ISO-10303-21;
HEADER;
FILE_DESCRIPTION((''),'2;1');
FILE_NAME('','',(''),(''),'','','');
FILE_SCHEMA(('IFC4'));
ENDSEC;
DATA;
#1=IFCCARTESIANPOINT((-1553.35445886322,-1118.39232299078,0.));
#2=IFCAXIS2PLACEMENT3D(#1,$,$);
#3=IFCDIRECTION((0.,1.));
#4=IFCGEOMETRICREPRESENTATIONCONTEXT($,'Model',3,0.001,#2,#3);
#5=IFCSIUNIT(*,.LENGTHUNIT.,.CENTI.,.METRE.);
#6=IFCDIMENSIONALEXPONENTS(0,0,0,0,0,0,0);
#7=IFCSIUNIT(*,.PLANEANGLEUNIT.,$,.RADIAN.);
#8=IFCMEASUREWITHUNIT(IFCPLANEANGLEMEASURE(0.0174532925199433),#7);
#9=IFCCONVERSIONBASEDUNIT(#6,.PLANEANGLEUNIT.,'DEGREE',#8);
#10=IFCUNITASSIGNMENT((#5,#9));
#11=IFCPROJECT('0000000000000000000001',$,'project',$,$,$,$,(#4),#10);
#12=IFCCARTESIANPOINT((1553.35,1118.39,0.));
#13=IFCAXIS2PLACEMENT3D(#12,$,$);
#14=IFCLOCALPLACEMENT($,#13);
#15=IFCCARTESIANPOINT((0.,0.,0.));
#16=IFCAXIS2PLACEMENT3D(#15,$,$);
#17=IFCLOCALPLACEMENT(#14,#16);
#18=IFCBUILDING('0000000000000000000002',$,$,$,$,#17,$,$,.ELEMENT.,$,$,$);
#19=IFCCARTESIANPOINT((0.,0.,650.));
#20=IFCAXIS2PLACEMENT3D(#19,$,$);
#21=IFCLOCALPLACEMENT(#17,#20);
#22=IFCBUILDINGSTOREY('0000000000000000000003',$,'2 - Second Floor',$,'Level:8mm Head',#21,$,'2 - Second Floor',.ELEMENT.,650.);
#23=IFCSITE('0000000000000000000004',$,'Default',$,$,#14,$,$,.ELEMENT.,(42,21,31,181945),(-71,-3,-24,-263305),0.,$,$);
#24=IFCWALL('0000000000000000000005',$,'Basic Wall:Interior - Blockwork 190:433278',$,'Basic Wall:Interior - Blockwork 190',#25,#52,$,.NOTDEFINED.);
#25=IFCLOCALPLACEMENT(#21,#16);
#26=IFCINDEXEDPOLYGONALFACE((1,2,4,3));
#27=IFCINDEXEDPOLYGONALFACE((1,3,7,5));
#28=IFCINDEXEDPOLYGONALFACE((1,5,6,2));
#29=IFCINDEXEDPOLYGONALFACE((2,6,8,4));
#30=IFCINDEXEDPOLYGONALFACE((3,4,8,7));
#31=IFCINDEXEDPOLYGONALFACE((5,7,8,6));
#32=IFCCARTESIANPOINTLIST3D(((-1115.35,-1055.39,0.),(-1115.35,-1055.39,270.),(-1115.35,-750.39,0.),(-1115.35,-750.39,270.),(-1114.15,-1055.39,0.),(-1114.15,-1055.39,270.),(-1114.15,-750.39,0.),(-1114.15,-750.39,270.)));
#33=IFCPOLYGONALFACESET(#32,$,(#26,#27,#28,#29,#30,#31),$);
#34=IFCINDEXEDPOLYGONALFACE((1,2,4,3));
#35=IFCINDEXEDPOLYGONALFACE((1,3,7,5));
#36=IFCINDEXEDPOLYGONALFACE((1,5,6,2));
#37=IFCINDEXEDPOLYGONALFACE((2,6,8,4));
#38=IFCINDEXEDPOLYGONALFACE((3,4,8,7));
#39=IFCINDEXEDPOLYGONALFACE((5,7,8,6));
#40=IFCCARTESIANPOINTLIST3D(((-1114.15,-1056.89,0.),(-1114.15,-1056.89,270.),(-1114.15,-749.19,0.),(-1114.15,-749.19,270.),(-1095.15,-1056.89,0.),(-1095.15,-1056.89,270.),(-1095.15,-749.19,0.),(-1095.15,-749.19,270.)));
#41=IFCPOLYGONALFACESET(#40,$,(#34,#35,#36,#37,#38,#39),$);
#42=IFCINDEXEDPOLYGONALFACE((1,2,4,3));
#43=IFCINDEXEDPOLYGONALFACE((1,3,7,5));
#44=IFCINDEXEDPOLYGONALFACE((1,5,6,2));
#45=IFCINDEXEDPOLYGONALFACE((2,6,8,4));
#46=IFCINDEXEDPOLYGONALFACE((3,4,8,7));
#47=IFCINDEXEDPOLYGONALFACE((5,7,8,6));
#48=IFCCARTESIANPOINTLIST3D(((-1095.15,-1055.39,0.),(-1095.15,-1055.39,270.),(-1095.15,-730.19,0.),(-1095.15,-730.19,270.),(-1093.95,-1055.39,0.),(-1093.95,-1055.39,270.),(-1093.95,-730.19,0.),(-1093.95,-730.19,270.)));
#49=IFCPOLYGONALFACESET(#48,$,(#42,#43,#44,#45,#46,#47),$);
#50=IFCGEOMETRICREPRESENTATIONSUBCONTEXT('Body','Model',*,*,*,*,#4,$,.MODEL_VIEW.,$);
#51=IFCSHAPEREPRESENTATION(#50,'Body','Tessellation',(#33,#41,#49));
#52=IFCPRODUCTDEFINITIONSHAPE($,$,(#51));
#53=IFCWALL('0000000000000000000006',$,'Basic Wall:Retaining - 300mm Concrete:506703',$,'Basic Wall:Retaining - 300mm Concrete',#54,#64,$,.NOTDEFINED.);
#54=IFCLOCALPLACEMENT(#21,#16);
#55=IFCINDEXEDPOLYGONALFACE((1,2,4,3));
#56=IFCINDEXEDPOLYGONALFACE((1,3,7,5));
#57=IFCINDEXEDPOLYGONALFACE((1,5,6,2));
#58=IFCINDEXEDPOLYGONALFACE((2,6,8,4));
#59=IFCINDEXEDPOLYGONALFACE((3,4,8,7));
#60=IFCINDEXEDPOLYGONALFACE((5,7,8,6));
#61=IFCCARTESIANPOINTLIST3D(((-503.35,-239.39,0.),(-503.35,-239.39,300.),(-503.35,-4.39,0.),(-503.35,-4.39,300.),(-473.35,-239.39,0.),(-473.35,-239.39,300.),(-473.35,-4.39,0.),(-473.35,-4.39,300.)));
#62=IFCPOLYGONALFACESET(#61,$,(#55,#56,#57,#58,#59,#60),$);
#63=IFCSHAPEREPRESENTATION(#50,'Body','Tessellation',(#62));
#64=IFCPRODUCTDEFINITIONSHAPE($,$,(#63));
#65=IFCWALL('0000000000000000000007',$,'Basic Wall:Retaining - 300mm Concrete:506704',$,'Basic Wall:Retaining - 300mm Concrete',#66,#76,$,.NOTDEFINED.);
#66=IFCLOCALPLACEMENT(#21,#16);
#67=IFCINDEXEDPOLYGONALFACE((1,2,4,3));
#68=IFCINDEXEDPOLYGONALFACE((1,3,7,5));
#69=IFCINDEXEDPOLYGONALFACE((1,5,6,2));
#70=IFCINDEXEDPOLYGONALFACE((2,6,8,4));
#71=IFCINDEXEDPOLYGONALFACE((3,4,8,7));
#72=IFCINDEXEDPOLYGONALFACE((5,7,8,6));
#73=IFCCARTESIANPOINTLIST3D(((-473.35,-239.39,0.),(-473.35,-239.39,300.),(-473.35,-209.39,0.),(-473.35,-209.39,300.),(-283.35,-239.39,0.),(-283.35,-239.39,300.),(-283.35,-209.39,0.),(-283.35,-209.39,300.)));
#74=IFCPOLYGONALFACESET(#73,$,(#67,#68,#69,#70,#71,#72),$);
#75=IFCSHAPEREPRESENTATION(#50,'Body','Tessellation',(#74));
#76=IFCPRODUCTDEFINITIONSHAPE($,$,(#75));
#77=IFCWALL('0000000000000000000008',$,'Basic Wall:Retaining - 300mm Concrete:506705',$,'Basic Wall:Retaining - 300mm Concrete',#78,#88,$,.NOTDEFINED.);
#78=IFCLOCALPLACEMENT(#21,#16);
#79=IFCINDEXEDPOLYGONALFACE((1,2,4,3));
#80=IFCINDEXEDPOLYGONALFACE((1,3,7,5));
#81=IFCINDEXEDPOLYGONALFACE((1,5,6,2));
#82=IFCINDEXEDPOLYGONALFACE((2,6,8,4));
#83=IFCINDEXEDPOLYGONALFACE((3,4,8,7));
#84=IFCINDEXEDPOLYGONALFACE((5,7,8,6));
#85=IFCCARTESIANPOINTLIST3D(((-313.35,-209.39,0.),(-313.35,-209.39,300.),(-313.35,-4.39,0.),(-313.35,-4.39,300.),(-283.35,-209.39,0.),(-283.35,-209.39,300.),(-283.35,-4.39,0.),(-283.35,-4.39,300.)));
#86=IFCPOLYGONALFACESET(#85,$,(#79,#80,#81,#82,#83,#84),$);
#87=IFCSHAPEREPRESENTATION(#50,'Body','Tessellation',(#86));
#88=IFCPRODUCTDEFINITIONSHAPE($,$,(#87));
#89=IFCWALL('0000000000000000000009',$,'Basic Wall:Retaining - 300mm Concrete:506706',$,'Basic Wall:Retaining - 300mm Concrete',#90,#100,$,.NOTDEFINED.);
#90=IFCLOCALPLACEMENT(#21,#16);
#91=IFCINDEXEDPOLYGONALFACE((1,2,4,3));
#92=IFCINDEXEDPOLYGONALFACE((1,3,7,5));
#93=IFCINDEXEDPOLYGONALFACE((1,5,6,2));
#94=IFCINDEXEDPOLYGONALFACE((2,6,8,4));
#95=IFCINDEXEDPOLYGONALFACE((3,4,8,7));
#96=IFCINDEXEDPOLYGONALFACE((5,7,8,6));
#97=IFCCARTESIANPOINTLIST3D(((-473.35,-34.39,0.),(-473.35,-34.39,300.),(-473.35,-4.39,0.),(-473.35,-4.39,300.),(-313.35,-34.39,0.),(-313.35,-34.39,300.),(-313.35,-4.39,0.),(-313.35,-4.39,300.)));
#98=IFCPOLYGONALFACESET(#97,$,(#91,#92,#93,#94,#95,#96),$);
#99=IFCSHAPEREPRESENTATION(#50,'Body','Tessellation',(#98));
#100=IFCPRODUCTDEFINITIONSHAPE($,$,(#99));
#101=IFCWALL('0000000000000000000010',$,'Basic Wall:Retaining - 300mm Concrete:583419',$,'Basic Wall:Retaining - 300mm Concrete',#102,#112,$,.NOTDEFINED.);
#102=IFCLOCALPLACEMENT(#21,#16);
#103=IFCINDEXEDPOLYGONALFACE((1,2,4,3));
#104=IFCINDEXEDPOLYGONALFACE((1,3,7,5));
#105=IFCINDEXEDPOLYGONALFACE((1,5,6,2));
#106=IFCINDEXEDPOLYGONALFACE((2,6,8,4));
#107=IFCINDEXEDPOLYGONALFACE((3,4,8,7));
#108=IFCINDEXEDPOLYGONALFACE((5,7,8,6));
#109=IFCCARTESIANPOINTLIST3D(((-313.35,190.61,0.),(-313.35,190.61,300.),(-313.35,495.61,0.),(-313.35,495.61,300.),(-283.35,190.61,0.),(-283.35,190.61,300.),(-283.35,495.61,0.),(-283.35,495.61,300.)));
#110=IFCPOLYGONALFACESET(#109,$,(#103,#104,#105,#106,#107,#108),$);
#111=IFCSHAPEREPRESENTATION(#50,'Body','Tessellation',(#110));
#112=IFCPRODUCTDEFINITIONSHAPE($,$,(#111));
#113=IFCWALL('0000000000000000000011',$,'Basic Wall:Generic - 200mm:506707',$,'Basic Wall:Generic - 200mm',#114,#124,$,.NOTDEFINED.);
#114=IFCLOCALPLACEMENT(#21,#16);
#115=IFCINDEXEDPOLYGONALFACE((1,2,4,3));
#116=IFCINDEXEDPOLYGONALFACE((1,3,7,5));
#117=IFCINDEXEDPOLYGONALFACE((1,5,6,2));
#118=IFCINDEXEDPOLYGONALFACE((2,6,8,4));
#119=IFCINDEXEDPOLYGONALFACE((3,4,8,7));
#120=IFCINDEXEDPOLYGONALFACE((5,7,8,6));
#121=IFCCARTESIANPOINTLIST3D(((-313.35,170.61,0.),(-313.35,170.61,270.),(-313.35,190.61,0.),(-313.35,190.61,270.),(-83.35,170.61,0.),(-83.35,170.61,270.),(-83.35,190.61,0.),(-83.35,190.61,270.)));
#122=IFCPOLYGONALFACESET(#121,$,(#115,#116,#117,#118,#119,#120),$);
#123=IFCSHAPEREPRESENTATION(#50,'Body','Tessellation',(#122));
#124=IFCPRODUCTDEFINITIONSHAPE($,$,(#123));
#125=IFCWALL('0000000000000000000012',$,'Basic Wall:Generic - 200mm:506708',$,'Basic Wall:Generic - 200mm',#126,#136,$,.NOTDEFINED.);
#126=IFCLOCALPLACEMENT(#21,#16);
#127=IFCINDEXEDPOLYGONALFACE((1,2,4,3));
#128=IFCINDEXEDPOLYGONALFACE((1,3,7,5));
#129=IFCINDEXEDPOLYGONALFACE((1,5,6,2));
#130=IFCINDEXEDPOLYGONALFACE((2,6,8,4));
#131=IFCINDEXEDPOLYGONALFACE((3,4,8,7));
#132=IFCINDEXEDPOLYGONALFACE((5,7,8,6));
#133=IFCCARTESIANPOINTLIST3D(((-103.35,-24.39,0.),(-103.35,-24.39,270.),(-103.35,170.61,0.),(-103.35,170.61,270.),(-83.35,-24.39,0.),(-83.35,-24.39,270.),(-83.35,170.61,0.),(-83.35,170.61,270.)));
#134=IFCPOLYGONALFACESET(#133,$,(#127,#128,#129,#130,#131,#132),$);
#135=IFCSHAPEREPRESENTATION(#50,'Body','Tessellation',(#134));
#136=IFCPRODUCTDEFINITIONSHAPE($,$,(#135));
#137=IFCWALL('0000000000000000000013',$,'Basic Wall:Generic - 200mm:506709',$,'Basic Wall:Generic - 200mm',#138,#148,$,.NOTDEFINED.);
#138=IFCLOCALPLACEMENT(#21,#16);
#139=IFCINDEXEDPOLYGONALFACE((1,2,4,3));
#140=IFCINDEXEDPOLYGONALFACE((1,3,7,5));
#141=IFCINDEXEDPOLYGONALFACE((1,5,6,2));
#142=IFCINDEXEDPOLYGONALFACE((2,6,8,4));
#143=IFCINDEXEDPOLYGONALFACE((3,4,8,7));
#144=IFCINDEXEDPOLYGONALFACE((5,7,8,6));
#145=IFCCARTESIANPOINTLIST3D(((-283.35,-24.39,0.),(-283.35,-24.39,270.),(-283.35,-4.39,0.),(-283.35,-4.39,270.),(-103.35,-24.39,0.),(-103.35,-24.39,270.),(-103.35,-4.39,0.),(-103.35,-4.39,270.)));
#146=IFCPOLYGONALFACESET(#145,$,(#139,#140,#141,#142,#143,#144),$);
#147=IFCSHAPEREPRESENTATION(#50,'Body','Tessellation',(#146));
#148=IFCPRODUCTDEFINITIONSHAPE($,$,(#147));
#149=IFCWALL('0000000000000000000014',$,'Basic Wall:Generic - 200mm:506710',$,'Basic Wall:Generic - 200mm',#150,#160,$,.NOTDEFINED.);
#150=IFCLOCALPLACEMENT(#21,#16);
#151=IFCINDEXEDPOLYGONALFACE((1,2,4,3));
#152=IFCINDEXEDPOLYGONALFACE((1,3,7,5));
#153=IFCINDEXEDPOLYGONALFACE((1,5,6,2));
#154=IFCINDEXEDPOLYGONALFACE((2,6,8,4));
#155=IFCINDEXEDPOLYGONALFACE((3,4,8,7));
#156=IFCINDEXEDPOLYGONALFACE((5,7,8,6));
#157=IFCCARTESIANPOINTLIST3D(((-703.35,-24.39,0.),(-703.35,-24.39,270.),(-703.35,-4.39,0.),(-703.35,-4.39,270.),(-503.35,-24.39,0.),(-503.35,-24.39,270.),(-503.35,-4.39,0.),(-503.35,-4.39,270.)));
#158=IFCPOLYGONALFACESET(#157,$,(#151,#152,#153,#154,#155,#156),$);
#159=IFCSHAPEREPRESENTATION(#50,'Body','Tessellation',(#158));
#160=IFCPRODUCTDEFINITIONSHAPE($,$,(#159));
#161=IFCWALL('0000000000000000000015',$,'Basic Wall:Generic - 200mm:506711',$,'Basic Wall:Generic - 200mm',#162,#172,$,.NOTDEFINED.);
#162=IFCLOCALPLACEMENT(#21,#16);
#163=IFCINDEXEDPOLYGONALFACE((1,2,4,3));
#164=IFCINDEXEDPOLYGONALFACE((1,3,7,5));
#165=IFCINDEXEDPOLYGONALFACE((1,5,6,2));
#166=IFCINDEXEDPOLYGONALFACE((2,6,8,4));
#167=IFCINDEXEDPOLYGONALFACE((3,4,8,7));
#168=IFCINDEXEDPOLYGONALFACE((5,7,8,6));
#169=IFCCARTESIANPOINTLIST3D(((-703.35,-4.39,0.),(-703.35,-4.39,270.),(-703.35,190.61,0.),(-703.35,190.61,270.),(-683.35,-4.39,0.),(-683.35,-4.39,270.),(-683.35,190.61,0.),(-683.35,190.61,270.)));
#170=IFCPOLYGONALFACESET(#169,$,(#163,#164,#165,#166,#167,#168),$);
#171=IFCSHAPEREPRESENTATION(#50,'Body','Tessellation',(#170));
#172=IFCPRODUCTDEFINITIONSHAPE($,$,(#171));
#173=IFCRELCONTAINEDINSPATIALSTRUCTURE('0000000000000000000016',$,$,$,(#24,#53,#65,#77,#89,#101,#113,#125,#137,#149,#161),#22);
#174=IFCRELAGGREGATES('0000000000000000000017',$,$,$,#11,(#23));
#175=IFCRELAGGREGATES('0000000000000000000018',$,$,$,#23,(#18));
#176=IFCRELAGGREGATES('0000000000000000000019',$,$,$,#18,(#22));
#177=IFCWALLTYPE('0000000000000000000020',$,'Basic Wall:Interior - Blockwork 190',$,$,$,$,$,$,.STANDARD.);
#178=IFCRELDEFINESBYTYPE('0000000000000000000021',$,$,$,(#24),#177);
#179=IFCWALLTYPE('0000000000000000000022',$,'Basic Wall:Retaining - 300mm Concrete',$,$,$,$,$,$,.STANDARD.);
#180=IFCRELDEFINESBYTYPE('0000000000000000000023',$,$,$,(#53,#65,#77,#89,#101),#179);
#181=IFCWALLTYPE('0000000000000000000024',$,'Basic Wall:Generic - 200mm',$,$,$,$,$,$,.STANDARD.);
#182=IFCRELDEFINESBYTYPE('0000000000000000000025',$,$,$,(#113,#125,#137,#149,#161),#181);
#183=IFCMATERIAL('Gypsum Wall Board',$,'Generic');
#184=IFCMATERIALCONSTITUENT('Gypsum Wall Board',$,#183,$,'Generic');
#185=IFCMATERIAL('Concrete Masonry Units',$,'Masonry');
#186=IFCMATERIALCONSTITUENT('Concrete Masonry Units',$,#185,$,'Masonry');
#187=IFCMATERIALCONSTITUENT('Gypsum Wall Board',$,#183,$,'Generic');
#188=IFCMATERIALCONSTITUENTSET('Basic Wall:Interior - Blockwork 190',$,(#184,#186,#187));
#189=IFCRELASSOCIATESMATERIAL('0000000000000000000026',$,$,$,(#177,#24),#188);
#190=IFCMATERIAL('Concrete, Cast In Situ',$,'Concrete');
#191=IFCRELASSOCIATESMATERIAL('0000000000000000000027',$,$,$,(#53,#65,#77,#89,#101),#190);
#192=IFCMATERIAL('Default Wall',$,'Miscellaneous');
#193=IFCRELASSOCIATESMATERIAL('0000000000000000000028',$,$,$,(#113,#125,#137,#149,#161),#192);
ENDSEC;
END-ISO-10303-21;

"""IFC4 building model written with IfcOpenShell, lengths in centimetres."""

from ifc_helpers import new_model, entity, si_unit, converted_unit, direction, frame, origin, place, context, subcontext, project, spatial, indexed_curve, outline, extrude, material, constituent, constituent_set, type_object, element, save


model = new_model("IFC4")

# Units and contexts
model_context = context("Model", 3, precision=0.001, world=frame((-1553.35445886322, -1118.39232299078, 0.0)), true_north=direction((0.0, 1.0)))
body_context = subcontext(model_context, "Body", "Model", "MODEL_VIEW")
ifc_project = project(units=[si_unit("LENGTHUNIT", "METRE", prefix="CENTI"), converted_unit("PLANEANGLEUNIT", "DEGREE", entity("IfcPlaneAngleMeasure", 0.0174532925199433), si_unit("PLANEANGLEUNIT", "RADIAN"), dimensions=[0, 0, 0, 0, 0, 0, 0])], contexts=[model_context])

# Site, building, storey
site_placement = place(None, frame((1553.35, 1118.39, 0.0)))
site = spatial("IfcSite", under=ifc_project, at=site_placement, Name="Default", CompositionType="ELEMENT", RefLatitude=(42, 21, 31, 181945), RefLongitude=(-71, -3, -24, -263305), RefElevation=0.0)
building_placement = place(site_placement, origin())
building = spatial("IfcBuilding", under=site, at=building_placement, CompositionType="ELEMENT")
storey_placement = place(building_placement, frame((0.0, 0.0, 650.0)))
storey = spatial("IfcBuildingStorey", under=building, at=storey_placement, Name="2 - Second Floor", ObjectType="Level:8mm Head", LongName="2 - Second Floor", CompositionType="ELEMENT", Elevation=650.0)

# Shared definitions
ifc_material_1 = material(Name="Concrete Masonry Units", Category="Masonry")

# Shared definitions
ifc_material_2 = material(Name="Gypsum Wall Board", Category="Generic")
ifc_constituent_1 = constituent(ifc_material_2, Name="Gypsum Wall Board", Category="Generic")
ifc_constituent_2 = constituent(ifc_material_1, Name="Concrete Masonry Units", Category="Masonry")
ifc_constituent_3 = constituent(ifc_material_2, Name="Gypsum Wall Board", Category="Generic")
ifc_constituent_set_1 = constituent_set(constituents=[ifc_constituent_1, ifc_constituent_2, ifc_constituent_3], Name="Basic Wall:Interior - Blockwork 190")
wall_type_1 = type_object("IfcWallType", Name="Basic Wall:Interior - Blockwork 190", PredefinedType="STANDARD", material=ifc_constituent_set_1)

# Walls
wall_1_placement = place(storey_placement, frame((-1104.65, -750.39, 0.0), z_axis=(0.0, 0.0, 1.0), x_axis=(0.0, -1.0, 0.0)))
element("IfcWall", 1, at=wall_1_placement, inside=storey, type_object=wall_type_1, material=ifc_constituent_set_1, Name="Basic Wall:Interior - Blockwork 190:433278", ObjectType="Basic Wall:Interior - Blockwork 190", PredefinedType="NOTDEFINED", context=body_context, shape_type="SweptSolid", body=[
    extrude(outline(indexed_curve([(-0.6, -152.5), (0.6, -152.5), (0.6, 152.5), (-0.6, 152.5), (-0.6, -152.5)], self_intersect=False)), frame((152.5, -10.1, 0.0), z_axis=(0.0, 0.0, 1.0), x_axis=(0.0, 1.0, 0.0)), (0.0, 0.0, 1.0), 270.0),
    extrude(outline(indexed_curve([(-153.85, -9.5), (153.85, -9.5), (153.85, 9.5), (-153.85, 9.5), (-153.85, -9.5)], self_intersect=False)), frame((152.65, 0.0, 0.0)), (0.0, 0.0, 1.0), 270.0),
    extrude(outline(indexed_curve([(-0.6, -162.6), (0.6, -162.6), (0.6, 162.6), (-0.6, 162.6), (-0.6, -162.6)], self_intersect=False)), frame((142.4, 10.1, 0.0), z_axis=(0.0, 0.0, 1.0), x_axis=(0.0, -1.0, 0.0)), (0.0, 0.0, 1.0), 270.0),
])
ifc_material_3 = material(Name="Concrete, Cast In Situ", Category="Concrete")
wall_type_2 = type_object("IfcWallType", Name="Basic Wall:Retaining - 300mm Concrete", PredefinedType="STANDARD")
wall_2_placement = place(storey_placement, frame((-488.35, -4.39, 0.0), z_axis=(0.0, 0.0, 1.0), x_axis=(0.0, -1.0, 0.0)))
element("IfcWall", 2, at=wall_2_placement, inside=storey, type_object=wall_type_2, material=ifc_material_3, Name="Basic Wall:Retaining - 300mm Concrete:506703", ObjectType="Basic Wall:Retaining - 300mm Concrete", PredefinedType="NOTDEFINED", context=body_context, shape_type="SweptSolid", body=[
    extrude(outline(indexed_curve([(235.0, 15.0), (0.0, 15.0), (0.0, -15.0), (235.0, -15.0), (235.0, 15.0)], self_intersect=False)), origin(), (0.0, 0.0, 1.0), 300.0),
])
wall_3_placement = place(storey_placement, frame((-473.35, -224.39, 0.0)))
element("IfcWall", 3, at=wall_3_placement, inside=storey, type_object=wall_type_2, material=ifc_material_3, Name="Basic Wall:Retaining - 300mm Concrete:506704", ObjectType="Basic Wall:Retaining - 300mm Concrete", PredefinedType="NOTDEFINED", context=body_context, shape_type="SweptSolid", body=[
    extrude(outline(indexed_curve([(190.0, 15.0), (0.0, 15.0), (0.0, -15.0), (190.0, -15.0), (190.0, 15.0)], self_intersect=False)), origin(), (0.0, 0.0, 1.0), 300.0),
])
wall_4_placement = place(storey_placement, frame((-298.35, -209.39, 0.0), z_axis=(0.0, 0.0, 1.0), x_axis=(0.0, 1.0, 0.0)))
element("IfcWall", 4, at=wall_4_placement, inside=storey, type_object=wall_type_2, material=ifc_material_3, Name="Basic Wall:Retaining - 300mm Concrete:506705", ObjectType="Basic Wall:Retaining - 300mm Concrete", PredefinedType="NOTDEFINED", context=body_context, shape_type="SweptSolid", body=[
    extrude(outline(indexed_curve([(205.0, 15.0), (0.0, 15.0), (0.0, -15.0), (205.0, -15.0), (205.0, 15.0)], self_intersect=False)), origin(), (0.0, 0.0, 1.0), 300.0),
])
wall_5_placement = place(storey_placement, frame((-313.35, -19.39, 0.0), z_axis=(0.0, 0.0, 1.0), x_axis=(-1.0, 0.0, 0.0)))
element("IfcWall", 5, at=wall_5_placement, inside=storey, type_object=wall_type_2, material=ifc_material_3, Name="Basic Wall:Retaining - 300mm Concrete:506706", ObjectType="Basic Wall:Retaining - 300mm Concrete", PredefinedType="NOTDEFINED", context=body_context, shape_type="SweptSolid", body=[
    extrude(outline(indexed_curve([(160.0, 15.0), (0.0, 15.0), (0.0, -15.0), (160.0, -15.0), (160.0, 15.0)], self_intersect=False)), origin(), (0.0, 0.0, 1.0), 300.0),
])
wall_6_placement = place(storey_placement, frame((-298.35, 495.61, 0.0), z_axis=(0.0, 0.0, 1.0), x_axis=(0.0, -1.0, 0.0)))
element("IfcWall", 6, at=wall_6_placement, inside=storey, type_object=wall_type_2, material=ifc_material_3, Name="Basic Wall:Retaining - 300mm Concrete:583419", ObjectType="Basic Wall:Retaining - 300mm Concrete", PredefinedType="NOTDEFINED", context=body_context, shape_type="SweptSolid", body=[
    extrude(outline(indexed_curve([(305.0, 15.0), (0.0, 15.0), (0.0, -15.0), (305.0, -15.0), (305.0, 15.0)], self_intersect=False)), origin(), (0.0, 0.0, 1.0), 300.0),
])
ifc_material_4 = material(Name="Default Wall", Category="Miscellaneous")
wall_type_3 = type_object("IfcWallType", Name="Basic Wall:Generic - 200mm", PredefinedType="STANDARD")
wall_7_placement = place(storey_placement, frame((-313.35, 180.61, 0.0)))
element("IfcWall", 7, at=wall_7_placement, inside=storey, type_object=wall_type_3, material=ifc_material_4, Name="Basic Wall:Generic - 200mm:506707", ObjectType="Basic Wall:Generic - 200mm", PredefinedType="NOTDEFINED", context=body_context, shape_type="SweptSolid", body=[
    extrude(outline(indexed_curve([(230.0, 10.0), (0.0, 10.0), (0.0, -10.0), (230.0, -10.0), (230.0, 10.0)], self_intersect=False)), origin(), (0.0, 0.0, 1.0), 270.0),
])
wall_8_placement = place(storey_placement, frame((-93.35, 170.61, 0.0), z_axis=(0.0, 0.0, 1.0), x_axis=(0.0, -1.0, 0.0)))
element("IfcWall", 8, at=wall_8_placement, inside=storey, type_object=wall_type_3, material=ifc_material_4, Name="Basic Wall:Generic - 200mm:506708", ObjectType="Basic Wall:Generic - 200mm", PredefinedType="NOTDEFINED", context=body_context, shape_type="SweptSolid", body=[
    extrude(outline(indexed_curve([(195.0, 10.0), (0.0, 10.0), (0.0, -10.0), (195.0, -10.0), (195.0, 10.0)], self_intersect=False)), origin(), (0.0, 0.0, 1.0), 270.0),
])
wall_9_placement = place(storey_placement, frame((-283.35, -14.39, 0.0)))
element("IfcWall", 9, at=wall_9_placement, inside=storey, type_object=wall_type_3, material=ifc_material_4, Name="Basic Wall:Generic - 200mm:506709", ObjectType="Basic Wall:Generic - 200mm", PredefinedType="NOTDEFINED", context=body_context, shape_type="SweptSolid", body=[
    extrude(outline(indexed_curve([(180.0, 10.0), (0.0, 10.0), (0.0, -10.0), (180.0, -10.0), (180.0, 10.0)], self_intersect=False)), origin(), (0.0, 0.0, 1.0), 270.0),
])
wall_10_placement = place(storey_placement, frame((-503.35, -14.39, 0.0), z_axis=(0.0, 0.0, 1.0), x_axis=(-1.0, 0.0, 0.0)))
element("IfcWall", 10, at=wall_10_placement, inside=storey, type_object=wall_type_3, material=ifc_material_4, Name="Basic Wall:Generic - 200mm:506710", ObjectType="Basic Wall:Generic - 200mm", PredefinedType="NOTDEFINED", context=body_context, shape_type="SweptSolid", body=[
    extrude(outline(indexed_curve([(200.0, 10.0), (0.0, 10.0), (0.0, -10.0), (200.0, -10.0), (200.0, 10.0)], self_intersect=False)), origin(), (0.0, 0.0, 1.0), 270.0),
])
wall_11_placement = place(storey_placement, frame((-693.35, -4.39, 0.0), z_axis=(0.0, 0.0, 1.0), x_axis=(0.0, 1.0, 0.0)))
element("IfcWall", 11, at=wall_11_placement, inside=storey, type_object=wall_type_3, material=ifc_material_4, Name="Basic Wall:Generic - 200mm:506711", ObjectType="Basic Wall:Generic - 200mm", PredefinedType="NOTDEFINED", context=body_context, shape_type="SweptSolid", body=[
    extrude(outline(indexed_curve([(195.0, 10.0), (0.0, 10.0), (0.0, -10.0), (195.0, -10.0), (195.0, 10.0)], self_intersect=False)), origin(), (0.0, 0.0, 1.0), 270.0),
])

save(model, "model.ifc")
